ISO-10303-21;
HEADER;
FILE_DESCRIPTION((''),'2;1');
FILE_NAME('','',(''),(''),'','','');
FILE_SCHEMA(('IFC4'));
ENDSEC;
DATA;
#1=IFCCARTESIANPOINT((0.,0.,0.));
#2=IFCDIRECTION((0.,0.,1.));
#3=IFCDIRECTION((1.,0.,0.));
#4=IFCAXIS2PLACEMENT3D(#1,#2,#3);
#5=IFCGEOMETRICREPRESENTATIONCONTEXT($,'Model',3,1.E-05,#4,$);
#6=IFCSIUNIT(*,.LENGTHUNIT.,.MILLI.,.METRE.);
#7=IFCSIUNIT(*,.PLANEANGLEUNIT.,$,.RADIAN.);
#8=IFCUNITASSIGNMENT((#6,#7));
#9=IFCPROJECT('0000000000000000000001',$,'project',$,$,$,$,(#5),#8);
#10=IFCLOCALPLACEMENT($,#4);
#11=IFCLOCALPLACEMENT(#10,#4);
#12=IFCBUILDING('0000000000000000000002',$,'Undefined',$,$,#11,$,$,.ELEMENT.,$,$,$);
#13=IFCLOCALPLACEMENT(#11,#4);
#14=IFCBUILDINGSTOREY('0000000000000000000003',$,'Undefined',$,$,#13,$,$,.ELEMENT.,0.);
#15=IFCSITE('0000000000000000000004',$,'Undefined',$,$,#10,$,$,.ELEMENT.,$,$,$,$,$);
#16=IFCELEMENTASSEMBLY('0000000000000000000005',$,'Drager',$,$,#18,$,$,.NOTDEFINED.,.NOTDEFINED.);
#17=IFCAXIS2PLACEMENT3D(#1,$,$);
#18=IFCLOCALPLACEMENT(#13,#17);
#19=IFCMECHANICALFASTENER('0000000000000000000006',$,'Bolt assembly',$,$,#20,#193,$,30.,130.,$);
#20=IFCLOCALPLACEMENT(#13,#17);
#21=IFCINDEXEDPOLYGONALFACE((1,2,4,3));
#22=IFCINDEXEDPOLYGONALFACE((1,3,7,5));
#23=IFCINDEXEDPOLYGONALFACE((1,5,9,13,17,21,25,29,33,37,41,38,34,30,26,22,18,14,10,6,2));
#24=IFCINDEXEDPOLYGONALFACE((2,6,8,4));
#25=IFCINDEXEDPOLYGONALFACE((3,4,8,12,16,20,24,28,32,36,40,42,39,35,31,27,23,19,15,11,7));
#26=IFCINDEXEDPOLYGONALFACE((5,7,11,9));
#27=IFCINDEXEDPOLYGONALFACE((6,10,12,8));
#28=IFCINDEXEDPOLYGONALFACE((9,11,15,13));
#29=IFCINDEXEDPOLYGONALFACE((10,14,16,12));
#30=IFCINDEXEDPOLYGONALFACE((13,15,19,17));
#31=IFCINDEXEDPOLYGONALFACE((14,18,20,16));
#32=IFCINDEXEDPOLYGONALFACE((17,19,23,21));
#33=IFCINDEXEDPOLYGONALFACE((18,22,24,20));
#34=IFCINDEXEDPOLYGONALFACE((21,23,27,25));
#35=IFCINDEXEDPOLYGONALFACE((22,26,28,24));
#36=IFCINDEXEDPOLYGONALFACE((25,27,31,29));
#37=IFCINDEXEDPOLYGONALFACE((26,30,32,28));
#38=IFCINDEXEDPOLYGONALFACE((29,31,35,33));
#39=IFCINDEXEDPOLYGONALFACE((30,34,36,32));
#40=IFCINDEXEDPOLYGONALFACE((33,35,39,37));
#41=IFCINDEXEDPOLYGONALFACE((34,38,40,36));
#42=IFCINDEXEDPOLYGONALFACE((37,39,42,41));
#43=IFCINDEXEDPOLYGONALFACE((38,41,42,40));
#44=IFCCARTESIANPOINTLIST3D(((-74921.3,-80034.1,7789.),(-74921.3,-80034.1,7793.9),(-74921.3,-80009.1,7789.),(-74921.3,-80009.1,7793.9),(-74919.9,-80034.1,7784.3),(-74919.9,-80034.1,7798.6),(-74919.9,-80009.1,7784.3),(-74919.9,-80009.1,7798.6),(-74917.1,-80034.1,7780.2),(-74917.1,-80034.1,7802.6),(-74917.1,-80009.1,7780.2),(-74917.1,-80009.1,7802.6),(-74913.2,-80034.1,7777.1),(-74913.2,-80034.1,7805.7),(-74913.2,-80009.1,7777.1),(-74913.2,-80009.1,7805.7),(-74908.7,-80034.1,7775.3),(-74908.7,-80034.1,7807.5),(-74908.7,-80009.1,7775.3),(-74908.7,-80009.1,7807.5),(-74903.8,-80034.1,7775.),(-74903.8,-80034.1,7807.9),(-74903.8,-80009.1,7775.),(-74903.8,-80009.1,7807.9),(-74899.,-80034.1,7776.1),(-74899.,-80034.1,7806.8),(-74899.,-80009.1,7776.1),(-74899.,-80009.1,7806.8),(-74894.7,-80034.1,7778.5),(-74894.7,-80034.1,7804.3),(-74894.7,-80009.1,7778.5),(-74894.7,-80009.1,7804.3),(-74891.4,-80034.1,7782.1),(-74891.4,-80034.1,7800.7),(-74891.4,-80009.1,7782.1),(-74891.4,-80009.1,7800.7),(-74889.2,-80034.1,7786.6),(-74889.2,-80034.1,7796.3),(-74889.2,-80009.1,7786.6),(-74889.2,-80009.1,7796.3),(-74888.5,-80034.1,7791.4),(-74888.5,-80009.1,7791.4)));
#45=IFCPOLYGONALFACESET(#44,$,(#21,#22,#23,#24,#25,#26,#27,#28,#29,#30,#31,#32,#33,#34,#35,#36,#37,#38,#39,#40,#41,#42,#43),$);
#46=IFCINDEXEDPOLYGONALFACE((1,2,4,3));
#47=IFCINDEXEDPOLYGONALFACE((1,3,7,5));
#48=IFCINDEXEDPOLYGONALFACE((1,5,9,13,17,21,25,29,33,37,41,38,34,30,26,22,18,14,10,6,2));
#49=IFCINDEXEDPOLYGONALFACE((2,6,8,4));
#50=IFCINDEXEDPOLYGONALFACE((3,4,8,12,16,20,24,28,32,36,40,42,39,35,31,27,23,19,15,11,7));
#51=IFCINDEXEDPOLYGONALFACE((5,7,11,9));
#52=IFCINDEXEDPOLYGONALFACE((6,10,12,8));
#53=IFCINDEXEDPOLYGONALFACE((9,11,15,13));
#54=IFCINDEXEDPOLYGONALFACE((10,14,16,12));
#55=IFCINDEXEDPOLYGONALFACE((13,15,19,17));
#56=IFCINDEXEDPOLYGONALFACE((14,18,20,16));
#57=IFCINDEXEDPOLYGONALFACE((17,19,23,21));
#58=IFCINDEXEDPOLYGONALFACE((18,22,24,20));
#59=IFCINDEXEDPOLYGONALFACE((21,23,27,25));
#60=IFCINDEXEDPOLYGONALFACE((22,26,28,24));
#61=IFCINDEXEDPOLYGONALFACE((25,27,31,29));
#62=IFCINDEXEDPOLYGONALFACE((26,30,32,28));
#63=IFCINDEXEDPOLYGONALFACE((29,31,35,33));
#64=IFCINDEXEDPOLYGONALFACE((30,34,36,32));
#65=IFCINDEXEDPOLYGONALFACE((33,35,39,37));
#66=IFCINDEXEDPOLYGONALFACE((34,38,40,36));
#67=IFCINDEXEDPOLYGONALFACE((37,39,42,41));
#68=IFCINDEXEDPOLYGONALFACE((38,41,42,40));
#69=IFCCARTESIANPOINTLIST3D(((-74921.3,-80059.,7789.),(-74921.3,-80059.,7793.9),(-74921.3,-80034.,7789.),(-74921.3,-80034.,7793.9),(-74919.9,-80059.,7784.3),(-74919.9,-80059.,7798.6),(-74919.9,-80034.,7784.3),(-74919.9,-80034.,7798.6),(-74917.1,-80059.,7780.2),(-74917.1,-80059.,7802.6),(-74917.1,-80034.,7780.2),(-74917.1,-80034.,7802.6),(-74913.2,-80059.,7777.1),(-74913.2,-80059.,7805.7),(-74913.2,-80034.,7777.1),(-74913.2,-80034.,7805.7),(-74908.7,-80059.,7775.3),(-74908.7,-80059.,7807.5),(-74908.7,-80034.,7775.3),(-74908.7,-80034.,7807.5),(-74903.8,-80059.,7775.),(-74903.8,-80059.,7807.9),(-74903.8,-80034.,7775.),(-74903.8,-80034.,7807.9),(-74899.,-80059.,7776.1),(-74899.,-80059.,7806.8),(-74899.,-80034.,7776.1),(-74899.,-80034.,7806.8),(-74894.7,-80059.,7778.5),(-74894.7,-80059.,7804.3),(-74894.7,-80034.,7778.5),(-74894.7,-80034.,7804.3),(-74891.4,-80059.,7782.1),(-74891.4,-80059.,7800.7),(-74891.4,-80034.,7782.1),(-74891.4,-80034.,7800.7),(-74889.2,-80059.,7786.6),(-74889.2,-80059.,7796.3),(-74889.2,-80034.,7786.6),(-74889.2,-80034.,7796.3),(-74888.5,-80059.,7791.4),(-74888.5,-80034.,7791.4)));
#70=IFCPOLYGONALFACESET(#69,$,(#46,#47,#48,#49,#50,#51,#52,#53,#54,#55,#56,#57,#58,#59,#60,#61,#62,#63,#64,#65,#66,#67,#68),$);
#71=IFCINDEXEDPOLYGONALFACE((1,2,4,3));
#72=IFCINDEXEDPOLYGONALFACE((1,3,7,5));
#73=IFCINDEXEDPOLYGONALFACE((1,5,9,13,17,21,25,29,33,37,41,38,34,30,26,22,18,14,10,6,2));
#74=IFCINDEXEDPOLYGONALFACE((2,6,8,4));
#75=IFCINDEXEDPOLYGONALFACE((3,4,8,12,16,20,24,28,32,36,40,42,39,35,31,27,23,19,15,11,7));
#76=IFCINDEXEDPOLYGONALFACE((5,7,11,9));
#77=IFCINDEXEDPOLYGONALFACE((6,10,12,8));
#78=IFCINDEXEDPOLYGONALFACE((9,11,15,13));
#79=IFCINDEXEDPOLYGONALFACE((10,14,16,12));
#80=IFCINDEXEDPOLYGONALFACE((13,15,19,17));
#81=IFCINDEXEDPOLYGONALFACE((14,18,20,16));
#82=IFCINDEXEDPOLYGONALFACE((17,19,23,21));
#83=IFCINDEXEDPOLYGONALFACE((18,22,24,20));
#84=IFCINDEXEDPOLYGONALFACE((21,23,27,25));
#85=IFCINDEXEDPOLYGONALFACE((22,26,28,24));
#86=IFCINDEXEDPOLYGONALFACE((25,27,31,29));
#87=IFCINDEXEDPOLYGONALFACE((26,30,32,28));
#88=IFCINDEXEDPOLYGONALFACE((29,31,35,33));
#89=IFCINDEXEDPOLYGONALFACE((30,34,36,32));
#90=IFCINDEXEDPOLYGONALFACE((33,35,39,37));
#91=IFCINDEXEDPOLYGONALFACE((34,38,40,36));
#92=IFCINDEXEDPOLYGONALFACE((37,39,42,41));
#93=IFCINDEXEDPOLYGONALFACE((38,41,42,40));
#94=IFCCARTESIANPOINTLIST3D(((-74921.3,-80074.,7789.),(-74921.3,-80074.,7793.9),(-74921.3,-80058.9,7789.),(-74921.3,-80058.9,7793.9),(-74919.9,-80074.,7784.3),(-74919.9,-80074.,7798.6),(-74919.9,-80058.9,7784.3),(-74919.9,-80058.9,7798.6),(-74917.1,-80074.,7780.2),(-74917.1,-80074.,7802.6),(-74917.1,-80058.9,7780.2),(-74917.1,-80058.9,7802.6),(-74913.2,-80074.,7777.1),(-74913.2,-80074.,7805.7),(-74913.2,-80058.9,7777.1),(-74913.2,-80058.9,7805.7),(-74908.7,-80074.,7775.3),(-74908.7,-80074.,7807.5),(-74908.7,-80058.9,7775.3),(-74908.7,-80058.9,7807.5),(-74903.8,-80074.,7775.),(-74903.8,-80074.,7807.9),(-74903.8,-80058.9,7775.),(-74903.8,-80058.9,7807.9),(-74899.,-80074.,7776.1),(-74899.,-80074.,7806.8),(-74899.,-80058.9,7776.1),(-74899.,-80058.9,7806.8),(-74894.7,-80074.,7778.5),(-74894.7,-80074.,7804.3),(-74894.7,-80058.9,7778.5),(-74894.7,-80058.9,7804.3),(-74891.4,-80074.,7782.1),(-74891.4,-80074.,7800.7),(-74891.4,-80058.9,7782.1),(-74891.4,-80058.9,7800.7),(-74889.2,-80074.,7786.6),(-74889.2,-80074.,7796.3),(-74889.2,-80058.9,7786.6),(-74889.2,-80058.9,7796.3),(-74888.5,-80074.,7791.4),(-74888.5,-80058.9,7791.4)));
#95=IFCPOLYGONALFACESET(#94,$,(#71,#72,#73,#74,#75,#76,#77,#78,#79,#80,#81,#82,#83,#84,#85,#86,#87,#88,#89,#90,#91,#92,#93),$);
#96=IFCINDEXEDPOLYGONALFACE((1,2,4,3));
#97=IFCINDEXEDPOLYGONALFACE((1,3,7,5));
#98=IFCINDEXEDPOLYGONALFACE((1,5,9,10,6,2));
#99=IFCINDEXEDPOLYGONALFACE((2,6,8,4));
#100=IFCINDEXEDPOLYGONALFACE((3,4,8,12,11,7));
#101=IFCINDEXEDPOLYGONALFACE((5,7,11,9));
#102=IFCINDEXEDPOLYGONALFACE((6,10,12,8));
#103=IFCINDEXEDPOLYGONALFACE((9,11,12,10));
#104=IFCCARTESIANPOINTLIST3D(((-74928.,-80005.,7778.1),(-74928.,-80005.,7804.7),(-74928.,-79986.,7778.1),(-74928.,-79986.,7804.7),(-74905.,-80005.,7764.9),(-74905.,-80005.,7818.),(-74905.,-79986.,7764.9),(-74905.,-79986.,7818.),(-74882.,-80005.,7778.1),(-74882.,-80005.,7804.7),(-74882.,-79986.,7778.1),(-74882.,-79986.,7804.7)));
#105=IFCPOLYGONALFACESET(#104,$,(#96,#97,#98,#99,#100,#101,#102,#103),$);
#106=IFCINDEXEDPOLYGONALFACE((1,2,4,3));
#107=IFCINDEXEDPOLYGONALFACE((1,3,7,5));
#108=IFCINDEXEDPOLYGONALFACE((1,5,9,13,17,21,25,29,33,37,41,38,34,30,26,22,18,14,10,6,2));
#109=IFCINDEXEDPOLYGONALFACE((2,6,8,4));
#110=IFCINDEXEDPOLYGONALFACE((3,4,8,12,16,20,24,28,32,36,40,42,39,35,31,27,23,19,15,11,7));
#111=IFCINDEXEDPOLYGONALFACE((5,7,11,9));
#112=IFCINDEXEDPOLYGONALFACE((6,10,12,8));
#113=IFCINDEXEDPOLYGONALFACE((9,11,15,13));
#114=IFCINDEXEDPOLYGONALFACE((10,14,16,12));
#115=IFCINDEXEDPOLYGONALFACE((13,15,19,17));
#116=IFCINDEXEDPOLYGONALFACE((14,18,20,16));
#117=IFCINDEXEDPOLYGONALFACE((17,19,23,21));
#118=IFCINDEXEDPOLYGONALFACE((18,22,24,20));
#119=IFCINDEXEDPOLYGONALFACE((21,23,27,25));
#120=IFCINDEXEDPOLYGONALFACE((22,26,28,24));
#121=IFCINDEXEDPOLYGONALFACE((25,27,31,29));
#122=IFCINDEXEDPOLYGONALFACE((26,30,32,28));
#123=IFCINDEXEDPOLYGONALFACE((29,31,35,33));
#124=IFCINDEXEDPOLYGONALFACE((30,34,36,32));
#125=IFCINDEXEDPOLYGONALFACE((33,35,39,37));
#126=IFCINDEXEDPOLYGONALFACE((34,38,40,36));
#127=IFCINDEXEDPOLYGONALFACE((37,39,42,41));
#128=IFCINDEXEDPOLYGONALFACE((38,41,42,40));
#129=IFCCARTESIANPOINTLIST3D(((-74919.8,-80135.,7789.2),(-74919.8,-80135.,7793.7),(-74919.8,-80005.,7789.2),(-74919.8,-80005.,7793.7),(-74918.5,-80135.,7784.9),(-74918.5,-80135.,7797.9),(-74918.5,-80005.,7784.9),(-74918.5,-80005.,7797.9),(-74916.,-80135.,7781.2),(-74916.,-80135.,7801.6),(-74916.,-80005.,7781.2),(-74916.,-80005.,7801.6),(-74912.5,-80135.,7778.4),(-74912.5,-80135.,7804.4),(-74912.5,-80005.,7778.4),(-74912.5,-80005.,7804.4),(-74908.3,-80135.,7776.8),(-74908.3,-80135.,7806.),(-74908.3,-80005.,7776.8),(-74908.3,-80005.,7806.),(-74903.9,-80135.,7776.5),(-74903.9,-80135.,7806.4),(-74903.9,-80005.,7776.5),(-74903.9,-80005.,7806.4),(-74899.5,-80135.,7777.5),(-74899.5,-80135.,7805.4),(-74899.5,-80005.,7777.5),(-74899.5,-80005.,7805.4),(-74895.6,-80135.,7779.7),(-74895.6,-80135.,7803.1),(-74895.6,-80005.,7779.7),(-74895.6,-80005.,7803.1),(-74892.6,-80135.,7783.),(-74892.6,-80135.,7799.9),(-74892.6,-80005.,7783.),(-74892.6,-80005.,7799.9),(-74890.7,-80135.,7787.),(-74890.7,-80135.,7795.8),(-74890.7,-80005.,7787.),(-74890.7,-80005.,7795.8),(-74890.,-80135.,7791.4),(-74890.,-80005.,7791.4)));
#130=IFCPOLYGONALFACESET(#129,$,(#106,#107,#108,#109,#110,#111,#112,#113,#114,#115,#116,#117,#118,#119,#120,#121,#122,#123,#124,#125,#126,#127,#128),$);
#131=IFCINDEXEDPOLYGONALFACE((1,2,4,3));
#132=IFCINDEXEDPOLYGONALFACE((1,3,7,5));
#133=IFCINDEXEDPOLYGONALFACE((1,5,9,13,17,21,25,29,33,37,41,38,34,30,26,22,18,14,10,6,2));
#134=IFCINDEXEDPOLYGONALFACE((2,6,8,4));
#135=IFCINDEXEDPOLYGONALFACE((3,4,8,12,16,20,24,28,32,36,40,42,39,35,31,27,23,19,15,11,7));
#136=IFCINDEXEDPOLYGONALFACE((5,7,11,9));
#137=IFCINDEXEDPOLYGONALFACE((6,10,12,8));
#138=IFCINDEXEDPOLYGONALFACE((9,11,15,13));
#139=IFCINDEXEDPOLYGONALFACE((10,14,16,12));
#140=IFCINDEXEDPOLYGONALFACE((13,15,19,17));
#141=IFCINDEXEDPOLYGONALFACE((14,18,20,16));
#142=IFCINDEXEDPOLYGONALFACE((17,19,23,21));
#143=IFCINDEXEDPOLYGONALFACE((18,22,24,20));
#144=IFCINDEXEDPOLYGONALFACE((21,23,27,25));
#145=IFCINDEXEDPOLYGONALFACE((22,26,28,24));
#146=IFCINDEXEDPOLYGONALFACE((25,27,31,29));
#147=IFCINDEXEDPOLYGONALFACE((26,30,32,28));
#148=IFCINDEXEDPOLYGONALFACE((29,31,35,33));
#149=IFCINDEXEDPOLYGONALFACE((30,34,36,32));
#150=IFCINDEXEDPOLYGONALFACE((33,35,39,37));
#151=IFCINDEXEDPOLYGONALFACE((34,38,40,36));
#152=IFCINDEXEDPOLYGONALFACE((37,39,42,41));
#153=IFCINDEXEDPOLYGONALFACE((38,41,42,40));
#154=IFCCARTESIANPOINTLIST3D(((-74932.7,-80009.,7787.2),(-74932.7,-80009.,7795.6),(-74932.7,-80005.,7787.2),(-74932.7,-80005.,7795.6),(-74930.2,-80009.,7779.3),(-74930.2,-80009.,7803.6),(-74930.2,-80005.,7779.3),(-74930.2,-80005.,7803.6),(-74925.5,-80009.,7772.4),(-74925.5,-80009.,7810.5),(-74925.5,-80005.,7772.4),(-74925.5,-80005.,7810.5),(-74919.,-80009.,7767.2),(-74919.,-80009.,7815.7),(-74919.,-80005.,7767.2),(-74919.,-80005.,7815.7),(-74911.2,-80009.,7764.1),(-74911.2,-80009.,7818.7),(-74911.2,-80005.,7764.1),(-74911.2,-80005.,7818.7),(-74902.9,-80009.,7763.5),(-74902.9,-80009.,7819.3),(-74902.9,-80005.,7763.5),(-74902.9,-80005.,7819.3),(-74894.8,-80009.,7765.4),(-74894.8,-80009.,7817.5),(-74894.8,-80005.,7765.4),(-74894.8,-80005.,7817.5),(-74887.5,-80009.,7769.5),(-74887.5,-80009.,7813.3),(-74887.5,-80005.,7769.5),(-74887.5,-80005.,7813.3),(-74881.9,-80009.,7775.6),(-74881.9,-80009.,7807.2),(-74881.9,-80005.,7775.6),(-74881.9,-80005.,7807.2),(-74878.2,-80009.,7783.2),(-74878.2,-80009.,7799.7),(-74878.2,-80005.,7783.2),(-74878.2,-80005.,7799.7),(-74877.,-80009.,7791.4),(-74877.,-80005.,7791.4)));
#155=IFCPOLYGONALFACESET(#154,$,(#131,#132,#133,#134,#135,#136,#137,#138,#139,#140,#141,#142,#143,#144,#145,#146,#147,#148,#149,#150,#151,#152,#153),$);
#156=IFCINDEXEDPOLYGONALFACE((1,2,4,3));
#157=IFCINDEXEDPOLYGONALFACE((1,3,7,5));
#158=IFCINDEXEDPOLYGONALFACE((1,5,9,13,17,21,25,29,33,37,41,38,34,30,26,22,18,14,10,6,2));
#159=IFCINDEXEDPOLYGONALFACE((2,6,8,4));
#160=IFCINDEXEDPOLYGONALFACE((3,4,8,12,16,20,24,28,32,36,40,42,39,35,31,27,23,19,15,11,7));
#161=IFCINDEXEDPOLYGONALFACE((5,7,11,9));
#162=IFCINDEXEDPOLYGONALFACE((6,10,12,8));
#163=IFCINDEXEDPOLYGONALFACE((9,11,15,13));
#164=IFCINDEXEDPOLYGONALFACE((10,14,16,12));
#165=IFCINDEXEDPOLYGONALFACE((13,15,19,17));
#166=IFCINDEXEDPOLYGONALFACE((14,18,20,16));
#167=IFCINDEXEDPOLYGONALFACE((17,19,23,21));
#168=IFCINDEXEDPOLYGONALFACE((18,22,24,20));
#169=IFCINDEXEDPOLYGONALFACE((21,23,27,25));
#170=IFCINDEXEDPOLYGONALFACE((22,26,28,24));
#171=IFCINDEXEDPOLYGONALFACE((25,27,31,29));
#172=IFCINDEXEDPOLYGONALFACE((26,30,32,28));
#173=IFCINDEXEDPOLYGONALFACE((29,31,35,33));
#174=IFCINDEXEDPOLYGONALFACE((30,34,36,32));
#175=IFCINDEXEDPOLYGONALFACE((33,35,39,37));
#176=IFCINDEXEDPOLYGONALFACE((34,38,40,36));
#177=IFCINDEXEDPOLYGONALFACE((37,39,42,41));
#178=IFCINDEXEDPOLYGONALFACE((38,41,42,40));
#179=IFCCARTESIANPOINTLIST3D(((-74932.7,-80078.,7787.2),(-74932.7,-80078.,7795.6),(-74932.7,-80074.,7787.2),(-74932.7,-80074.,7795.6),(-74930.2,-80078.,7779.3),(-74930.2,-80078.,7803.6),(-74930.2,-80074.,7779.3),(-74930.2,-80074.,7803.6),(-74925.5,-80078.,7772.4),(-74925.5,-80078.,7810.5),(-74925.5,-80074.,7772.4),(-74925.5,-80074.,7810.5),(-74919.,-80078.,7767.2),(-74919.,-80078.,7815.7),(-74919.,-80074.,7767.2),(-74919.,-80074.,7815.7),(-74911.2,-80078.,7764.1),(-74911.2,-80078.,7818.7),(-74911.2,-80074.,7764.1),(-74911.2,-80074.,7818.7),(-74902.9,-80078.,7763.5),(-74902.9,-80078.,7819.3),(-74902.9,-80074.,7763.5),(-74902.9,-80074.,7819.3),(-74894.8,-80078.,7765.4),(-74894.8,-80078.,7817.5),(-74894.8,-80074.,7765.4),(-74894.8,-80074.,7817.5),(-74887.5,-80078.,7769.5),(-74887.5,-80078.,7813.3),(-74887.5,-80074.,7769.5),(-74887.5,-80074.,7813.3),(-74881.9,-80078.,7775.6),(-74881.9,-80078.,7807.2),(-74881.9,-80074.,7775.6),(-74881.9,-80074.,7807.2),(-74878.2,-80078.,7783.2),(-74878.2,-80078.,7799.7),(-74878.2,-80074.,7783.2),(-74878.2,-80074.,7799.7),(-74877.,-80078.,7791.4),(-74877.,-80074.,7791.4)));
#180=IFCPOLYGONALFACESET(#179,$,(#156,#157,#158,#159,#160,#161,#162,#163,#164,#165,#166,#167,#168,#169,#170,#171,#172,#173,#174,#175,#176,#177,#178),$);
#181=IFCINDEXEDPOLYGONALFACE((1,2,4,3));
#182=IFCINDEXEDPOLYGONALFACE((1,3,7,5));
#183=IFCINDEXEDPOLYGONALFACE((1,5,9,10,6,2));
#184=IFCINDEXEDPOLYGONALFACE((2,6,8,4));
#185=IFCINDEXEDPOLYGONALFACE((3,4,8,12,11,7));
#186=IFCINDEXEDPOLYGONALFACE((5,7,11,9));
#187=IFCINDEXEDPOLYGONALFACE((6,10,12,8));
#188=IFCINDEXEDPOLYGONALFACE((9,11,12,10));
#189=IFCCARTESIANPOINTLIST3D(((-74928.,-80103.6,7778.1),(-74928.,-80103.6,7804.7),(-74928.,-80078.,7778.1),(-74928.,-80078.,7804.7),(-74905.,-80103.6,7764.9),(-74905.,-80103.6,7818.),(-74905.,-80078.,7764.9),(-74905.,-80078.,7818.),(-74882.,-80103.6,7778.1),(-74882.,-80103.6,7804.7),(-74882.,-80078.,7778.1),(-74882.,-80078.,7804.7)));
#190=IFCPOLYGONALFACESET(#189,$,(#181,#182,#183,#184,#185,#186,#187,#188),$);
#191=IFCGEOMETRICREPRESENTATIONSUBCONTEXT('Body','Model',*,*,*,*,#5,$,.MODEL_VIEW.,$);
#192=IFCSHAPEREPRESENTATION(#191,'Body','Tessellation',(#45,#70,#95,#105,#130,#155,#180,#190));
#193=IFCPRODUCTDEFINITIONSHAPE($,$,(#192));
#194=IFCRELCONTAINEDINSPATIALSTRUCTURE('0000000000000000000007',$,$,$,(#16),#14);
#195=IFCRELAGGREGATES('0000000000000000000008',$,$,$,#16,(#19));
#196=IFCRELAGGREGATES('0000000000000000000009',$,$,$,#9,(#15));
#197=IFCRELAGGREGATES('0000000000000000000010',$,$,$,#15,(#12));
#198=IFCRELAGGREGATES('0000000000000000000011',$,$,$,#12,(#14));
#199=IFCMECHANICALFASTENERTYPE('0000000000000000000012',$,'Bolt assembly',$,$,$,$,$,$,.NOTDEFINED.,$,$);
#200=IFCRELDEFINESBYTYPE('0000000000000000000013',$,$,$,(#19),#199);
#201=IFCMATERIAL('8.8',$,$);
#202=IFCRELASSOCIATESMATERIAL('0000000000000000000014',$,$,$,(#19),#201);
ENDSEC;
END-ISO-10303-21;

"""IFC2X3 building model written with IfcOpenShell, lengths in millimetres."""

from ifc_helpers import new_model, si_unit, frame, origin_with_axes, origin_2d_with_axis, place, context, subcontext, project, spatial, polyline, circle, outline, extrude, source, transform, mapped, material, type_object, element, aggregate, save


model = new_model("IFC2X3")

# Units and contexts
model_context = context("Model", 3, precision=1e-05, world=origin_with_axes())
body_context = subcontext(model_context, "Body", "Model", "MODEL_VIEW")
ifc_project = project(units=[si_unit("LENGTHUNIT", "METRE", prefix="MILLI"), si_unit("PLANEANGLEUNIT", "RADIAN")], contexts=[model_context])

# Site, building, storey
site_placement = place(None, origin_with_axes())
site = spatial("IfcSite", under=ifc_project, at=site_placement, Name="Undefined", CompositionType="ELEMENT")
building_placement = place(site_placement, origin_with_axes())
building = spatial("IfcBuilding", under=site, at=building_placement, Name="Undefined", CompositionType="ELEMENT")
storey_placement = place(building_placement, origin_with_axes())
storey = spatial("IfcBuildingStorey", under=building, at=storey_placement, Name="Undefined", CompositionType="ELEMENT", Elevation=0.0)

# Element assembly
assembly_1_placement = place(storey_placement, origin_with_axes())
assembly_1 = element("IfcElementAssembly", 1, at=assembly_1_placement, inside=storey, Name="Drager", AssemblyPlace="NOTDEFINED", PredefinedType="NOTDEFINED")

# Shared definitions
ifc_material_1 = material(Name="8.8")
mechanical_fastener_type = type_object("IfcMechanicalFastenerType", Name="Bolt assembly")

# Mechanical fastener
shared_shape_1 = source(origin_with_axes(), body_context, "Body", "SweptSolid", [
    extrude(circle(Radius=16.5, at=origin_2d_with_axis()), frame((0.0, -57.4, 0.0), z_axis=(0.0, 1.0, 0.0), x_axis=(1.0, 0.0, 0.0)), (0.0, 0.0, 1.0), 25.0),
    extrude(circle(Radius=16.5, at=origin_2d_with_axis()), frame((0.0, -32.5, 0.0), z_axis=(0.0, 1.0, 0.0), x_axis=(1.0, 0.0, 0.0)), (0.0, 0.0, 1.0), 25.0),
    extrude(circle(Radius=16.5, at=origin_2d_with_axis()), frame((0.0, -7.6, 0.0), z_axis=(0.0, 1.0, 0.0), x_axis=(1.0, 0.0, 0.0)), (0.0, 0.0, 1.0), 15.1),
    extrude(outline(polyline([(23.0, -13.3), (23.0, 13.3), (0.0, 26.6), (-23.0, 13.3), (-23.0, -13.3), (0.0, -26.6), (23.0, -13.3)])), frame((0.0, -80.5, 0.0), z_axis=(0.0, 1.0, 0.0), x_axis=(1.0, 0.0, 0.0)), (0.0, 0.0, 1.0), 19.0),
    extrude(circle(Radius=15.0, at=origin_2d_with_axis()), frame((0.0, -61.5, 0.0), z_axis=(0.0, 1.0, 0.0), x_axis=(1.0, 0.0, 0.0)), (0.0, 0.0, 1.0), 130.0),
    extrude(circle(Radius=28.0, at=origin_2d_with_axis()), frame((0.0, -61.5, 0.0), z_axis=(0.0, 1.0, 0.0), x_axis=(1.0, 0.0, 0.0)), (0.0, 0.0, 1.0), 4.0),
    extrude(circle(Radius=28.0, at=origin_2d_with_axis()), frame((0.0, 7.5, 0.0), z_axis=(0.0, 1.0, 0.0), x_axis=(1.0, 0.0, 0.0)), (0.0, 0.0, 1.0), 4.0),
    extrude(outline(polyline([(23.0, -13.3), (23.0, 13.3), (0.0, 26.6), (-23.0, 13.3), (-23.0, -13.3), (0.0, -26.6), (23.0, -13.3)])), frame((0.0, 11.5, 0.0), z_axis=(0.0, 1.0, 0.0), x_axis=(1.0, 0.0, 0.0)), (0.0, 0.0, 1.0), 25.6),
])
mechanical_fastener_1_placement = place(assembly_1_placement, frame((-74905.0, -80066.5, 7791.4), z_axis=(0.0, 0.0, -1.0), x_axis=(1.0, 0.0, 0.0)))
mechanical_fastener_1 = element("IfcMechanicalFastener", 2, at=mechanical_fastener_1_placement, type_object=mechanical_fastener_type, material=ifc_material_1, Name="Bolt assembly", NominalDiameter=30.0, NominalLength=130.0, context=body_context, shape_type="MappedRepresentation", body=[
    mapped(shared_shape_1, transform((0.0, 0.0, 0.0))),
])
aggregate(assembly_1, [mechanical_fastener_1])

save(model, "model.ifc")
